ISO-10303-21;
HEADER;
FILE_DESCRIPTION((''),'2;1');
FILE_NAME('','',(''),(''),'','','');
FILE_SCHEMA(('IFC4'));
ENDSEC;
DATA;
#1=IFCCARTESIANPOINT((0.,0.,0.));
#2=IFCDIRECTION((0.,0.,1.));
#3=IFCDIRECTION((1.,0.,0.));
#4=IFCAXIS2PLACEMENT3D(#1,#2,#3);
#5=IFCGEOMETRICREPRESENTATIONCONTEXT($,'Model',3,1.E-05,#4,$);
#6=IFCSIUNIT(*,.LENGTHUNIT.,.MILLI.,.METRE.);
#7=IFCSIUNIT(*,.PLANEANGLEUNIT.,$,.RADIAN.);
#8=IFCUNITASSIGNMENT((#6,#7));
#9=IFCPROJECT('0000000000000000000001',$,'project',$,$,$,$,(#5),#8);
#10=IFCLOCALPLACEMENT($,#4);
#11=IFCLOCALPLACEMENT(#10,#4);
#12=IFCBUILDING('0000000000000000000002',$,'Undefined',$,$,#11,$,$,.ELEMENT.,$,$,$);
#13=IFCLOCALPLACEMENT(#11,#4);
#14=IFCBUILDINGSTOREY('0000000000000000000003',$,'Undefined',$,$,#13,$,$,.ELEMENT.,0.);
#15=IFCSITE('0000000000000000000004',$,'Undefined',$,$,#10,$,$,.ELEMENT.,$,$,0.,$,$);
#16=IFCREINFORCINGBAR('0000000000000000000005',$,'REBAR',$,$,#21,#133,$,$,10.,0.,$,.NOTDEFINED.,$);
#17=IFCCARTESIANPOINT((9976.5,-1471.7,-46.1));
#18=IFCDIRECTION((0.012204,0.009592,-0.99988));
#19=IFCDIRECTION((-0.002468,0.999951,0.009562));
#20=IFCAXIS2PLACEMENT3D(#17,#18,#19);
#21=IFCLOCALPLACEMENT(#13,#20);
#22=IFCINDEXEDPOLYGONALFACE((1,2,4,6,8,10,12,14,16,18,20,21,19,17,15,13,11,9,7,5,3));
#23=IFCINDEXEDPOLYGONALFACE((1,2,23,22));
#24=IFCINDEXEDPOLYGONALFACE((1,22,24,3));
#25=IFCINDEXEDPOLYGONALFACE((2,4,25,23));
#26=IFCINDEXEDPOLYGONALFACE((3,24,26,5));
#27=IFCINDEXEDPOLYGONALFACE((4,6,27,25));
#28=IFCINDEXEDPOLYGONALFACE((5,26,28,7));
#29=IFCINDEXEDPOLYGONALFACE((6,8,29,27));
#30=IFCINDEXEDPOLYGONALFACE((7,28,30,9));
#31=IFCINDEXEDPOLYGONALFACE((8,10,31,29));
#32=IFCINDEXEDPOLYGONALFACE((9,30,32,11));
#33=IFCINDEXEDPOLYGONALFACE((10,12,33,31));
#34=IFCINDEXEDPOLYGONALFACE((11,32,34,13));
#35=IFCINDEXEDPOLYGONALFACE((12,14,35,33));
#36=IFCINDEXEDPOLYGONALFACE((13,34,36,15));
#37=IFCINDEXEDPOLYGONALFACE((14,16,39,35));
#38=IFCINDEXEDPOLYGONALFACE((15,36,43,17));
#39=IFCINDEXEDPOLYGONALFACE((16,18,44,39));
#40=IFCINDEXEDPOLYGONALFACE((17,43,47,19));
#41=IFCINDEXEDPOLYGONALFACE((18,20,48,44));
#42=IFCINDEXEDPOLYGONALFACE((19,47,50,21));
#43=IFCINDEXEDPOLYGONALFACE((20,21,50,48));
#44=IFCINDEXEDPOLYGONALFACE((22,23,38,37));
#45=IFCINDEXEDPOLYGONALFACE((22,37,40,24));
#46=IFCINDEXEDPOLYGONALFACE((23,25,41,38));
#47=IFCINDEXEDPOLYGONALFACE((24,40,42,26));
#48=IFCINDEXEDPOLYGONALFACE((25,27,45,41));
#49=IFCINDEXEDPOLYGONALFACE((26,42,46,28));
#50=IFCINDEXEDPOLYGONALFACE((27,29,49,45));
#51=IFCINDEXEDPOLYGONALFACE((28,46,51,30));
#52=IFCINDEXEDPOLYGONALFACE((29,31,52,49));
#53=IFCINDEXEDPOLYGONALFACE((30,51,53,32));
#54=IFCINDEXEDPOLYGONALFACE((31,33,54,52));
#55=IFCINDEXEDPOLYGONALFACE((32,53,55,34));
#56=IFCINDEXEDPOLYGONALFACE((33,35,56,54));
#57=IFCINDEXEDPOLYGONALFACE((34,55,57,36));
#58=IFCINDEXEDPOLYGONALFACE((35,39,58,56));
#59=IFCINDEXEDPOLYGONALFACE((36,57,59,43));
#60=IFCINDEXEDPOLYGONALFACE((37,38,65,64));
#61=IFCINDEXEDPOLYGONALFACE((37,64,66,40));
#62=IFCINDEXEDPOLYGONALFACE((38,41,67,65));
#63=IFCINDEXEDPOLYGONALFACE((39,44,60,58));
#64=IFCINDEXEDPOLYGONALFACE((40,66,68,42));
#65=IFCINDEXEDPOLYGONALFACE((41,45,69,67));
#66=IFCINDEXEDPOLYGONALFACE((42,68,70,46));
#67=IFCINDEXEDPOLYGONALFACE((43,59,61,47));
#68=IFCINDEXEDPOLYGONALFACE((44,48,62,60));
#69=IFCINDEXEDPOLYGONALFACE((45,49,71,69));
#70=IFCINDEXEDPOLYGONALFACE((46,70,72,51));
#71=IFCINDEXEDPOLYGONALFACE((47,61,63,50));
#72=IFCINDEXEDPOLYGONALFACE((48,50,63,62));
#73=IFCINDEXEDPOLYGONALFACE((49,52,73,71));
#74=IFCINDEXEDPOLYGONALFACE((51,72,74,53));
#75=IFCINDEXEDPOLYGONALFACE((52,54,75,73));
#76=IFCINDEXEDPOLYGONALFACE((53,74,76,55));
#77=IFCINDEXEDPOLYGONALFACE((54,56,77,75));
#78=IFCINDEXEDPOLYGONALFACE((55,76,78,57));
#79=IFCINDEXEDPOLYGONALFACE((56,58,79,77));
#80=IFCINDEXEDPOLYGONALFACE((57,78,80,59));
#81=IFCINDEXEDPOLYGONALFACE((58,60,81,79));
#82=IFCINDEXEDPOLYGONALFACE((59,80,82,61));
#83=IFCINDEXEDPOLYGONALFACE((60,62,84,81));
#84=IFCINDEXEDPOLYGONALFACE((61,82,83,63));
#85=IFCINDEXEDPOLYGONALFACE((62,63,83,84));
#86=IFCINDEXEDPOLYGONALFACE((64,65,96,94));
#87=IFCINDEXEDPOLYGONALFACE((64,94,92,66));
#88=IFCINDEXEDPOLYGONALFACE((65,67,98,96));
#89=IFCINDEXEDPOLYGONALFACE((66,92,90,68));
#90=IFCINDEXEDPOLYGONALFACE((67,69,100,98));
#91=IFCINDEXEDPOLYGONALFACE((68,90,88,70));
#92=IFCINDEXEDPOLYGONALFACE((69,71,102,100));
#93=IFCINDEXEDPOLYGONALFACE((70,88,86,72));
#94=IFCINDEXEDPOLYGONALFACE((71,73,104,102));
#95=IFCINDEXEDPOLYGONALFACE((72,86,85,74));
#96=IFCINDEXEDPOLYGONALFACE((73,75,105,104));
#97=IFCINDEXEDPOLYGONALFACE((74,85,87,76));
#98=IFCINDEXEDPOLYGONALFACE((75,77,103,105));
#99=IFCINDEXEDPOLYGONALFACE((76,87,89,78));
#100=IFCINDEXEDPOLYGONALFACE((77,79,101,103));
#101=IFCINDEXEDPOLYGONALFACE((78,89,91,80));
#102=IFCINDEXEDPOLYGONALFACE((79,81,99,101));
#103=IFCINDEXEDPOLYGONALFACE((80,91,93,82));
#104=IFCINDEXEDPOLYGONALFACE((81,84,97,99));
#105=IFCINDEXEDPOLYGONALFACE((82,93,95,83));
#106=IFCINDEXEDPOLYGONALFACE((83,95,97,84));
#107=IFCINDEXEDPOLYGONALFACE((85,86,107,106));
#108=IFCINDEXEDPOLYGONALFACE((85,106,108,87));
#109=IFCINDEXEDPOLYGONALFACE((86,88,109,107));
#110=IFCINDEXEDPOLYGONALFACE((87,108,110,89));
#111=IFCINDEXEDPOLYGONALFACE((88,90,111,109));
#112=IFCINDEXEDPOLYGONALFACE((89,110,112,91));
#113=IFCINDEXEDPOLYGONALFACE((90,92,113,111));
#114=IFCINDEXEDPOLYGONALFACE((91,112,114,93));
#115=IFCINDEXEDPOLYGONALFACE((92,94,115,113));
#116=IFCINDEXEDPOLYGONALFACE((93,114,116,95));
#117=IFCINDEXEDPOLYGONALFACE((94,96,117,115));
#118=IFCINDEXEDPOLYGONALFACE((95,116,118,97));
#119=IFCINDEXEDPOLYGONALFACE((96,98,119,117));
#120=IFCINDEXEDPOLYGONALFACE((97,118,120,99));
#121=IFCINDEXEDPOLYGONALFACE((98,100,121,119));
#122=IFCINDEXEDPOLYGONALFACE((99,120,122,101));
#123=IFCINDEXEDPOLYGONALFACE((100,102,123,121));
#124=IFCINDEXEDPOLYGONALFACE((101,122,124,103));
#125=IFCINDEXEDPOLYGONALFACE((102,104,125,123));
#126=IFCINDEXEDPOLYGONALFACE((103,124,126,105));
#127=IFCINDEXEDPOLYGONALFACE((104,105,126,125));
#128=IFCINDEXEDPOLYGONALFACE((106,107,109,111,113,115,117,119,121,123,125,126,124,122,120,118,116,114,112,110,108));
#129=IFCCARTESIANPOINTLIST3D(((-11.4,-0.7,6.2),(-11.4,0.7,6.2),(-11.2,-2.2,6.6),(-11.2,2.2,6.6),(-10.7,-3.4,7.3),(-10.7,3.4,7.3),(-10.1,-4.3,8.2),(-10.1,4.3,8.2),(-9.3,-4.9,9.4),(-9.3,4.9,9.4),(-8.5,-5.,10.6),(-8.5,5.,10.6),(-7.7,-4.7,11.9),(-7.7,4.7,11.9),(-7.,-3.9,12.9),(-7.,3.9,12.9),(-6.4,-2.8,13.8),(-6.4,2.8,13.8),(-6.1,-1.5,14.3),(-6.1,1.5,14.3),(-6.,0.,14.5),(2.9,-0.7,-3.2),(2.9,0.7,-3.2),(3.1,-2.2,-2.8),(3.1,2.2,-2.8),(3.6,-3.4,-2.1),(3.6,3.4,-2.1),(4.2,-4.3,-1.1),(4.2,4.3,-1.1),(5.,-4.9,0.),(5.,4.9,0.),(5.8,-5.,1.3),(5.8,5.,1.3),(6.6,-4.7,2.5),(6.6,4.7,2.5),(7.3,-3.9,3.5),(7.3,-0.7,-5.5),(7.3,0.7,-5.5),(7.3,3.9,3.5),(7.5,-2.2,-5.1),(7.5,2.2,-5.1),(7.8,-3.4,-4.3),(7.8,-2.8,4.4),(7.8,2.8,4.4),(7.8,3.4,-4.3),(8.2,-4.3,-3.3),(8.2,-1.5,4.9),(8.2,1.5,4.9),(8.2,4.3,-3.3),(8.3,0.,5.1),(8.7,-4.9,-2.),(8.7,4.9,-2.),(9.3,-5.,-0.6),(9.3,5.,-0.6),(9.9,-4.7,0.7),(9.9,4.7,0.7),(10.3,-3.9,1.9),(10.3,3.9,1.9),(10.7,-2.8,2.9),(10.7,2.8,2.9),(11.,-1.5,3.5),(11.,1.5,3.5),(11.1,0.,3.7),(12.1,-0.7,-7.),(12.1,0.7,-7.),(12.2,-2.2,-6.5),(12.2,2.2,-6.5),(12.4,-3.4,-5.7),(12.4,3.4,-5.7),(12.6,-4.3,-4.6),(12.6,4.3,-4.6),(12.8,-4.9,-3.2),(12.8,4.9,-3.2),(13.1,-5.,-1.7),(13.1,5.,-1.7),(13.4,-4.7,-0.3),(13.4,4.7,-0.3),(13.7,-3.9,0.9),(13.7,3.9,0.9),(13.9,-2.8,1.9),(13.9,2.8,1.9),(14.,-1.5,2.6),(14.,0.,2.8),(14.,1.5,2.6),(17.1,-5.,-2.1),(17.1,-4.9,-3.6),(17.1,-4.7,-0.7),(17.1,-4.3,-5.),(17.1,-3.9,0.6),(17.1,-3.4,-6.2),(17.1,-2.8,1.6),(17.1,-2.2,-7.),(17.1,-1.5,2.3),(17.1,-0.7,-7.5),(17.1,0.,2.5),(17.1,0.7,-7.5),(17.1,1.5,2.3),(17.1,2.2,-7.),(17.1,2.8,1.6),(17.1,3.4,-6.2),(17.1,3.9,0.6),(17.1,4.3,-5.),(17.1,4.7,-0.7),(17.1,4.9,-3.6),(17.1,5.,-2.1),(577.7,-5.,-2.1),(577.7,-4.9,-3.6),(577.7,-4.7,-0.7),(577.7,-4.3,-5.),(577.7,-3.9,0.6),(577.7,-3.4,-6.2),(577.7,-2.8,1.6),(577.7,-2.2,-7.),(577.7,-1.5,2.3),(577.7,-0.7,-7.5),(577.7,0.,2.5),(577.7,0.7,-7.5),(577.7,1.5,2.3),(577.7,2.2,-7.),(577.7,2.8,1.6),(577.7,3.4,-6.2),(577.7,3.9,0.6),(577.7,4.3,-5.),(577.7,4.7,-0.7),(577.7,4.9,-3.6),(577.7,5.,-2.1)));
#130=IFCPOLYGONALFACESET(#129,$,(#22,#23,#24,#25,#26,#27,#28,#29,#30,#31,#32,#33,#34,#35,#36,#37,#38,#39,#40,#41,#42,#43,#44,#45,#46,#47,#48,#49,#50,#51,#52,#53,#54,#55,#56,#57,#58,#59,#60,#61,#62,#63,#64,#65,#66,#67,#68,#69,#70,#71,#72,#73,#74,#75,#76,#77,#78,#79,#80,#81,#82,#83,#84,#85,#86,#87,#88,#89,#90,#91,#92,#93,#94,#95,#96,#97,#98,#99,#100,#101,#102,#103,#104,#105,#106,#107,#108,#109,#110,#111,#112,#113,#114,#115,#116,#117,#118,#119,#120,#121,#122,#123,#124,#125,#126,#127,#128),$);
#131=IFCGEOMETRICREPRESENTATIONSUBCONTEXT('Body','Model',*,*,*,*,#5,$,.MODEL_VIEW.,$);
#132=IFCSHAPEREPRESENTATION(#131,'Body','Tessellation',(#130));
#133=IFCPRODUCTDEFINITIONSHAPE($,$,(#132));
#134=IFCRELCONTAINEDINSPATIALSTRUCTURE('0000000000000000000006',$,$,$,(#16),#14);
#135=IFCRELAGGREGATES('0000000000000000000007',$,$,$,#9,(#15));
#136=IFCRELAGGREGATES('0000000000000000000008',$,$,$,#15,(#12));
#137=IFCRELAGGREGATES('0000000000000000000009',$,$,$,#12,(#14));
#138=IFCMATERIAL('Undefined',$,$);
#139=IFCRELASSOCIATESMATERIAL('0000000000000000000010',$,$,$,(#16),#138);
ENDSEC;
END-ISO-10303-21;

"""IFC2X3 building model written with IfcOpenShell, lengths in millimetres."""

from ifc_helpers import new_model, entity, si_unit, frame, origin_with_axes, place, context, subcontext, project, spatial, source, transform, mapped, material, element, save


model = new_model("IFC2X3")

# Units and contexts
model_context = context("Model", 3, precision=1e-05, world=origin_with_axes())
body_context = subcontext(model_context, "Body", "Model", "MODEL_VIEW")
ifc_project = project(units=[si_unit("LENGTHUNIT", "METRE", prefix="MILLI"), si_unit("PLANEANGLEUNIT", "RADIAN")], contexts=[model_context])

# Site, building, storey
site_placement = place(None, origin_with_axes())
site = spatial("IfcSite", under=ifc_project, at=site_placement, Name="Undefined", CompositionType="ELEMENT", RefElevation=0.0)
building_placement = place(site_placement, origin_with_axes())
building = spatial("IfcBuilding", under=site, at=building_placement, Name="Undefined", CompositionType="ELEMENT")
storey_placement = place(building_placement, origin_with_axes())
storey = spatial("IfcBuildingStorey", under=building, at=storey_placement, Name="Undefined", CompositionType="ELEMENT", Elevation=0.0)

# Reinforcing bar
ifc_material_1 = material(Name="Undefined")
shared_shape_1 = source(origin_with_axes(), body_context, "Body", "AdvancedSweptSolid", [
    entity("IfcSweptDiskSolid", entity("IfcCompositeCurve", [entity("IfcCompositeCurveSegment", "CONTINUOUS", True, entity("IfcTrimmedCurve", entity("IfcLine", entity("IfcCartesianPoint", [0.0, 0.0, 0.0]), entity("IfcVector", entity("IfcDirection", [0.835483, 0.0, -0.549516]), 1.0)), [entity("IfcParameterValue", 0.0)], [entity("IfcParameterValue", 17.082101)], True, "PARAMETER")), entity("IfcCompositeCurveSegment", "CONTINUOUS", True, entity("IfcTrimmedCurve", entity("IfcCircle", entity("IfcAxis2Placement3D", entity("IfcCartesianPoint", [25.8, 0.0, 8.2]), entity("IfcDirection", [0.0, -1.0, 0.0]), entity("IfcDirection", [-0.549516, 0.0, -0.835483])), 21.0), [entity("IfcParameterValue", 0.0)], [entity("IfcParameterValue", 0.581785)], True, "PARAMETER")), entity("IfcCompositeCurveSegment", "DISCONTINUOUS", True, entity("IfcTrimmedCurve", entity("IfcLine", entity("IfcCartesianPoint", [25.8, 0.0, -12.8]), entity("IfcVector", entity("IfcDirection", [1.0, 0.0, 0.0]), 1.0)), [entity("IfcParameterValue", 0.0)], [entity("IfcParameterValue", 560.593055)], True, "PARAMETER"))], False), 5.0, None, 0.0, 578.3),
])
reinforcing_bar_1_placement = place(storey_placement, frame((9976.5, -1471.7, -46.1), z_axis=(0.012204, 0.009592, -0.99988), x_axis=(-0.002468, 0.999951, 0.009562)))
element("IfcReinforcingBar", 1, at=reinforcing_bar_1_placement, inside=storey, material=ifc_material_1, Name="REBAR", BarRole="NOTDEFINED", CrossSectionArea=0.0, NominalDiameter=10.0, context=body_context, shape_type="MappedRepresentation", body=[
    mapped(shared_shape_1, transform((-8.7, 0.0, 10.3))),
])

save(model, "model.ifc")
